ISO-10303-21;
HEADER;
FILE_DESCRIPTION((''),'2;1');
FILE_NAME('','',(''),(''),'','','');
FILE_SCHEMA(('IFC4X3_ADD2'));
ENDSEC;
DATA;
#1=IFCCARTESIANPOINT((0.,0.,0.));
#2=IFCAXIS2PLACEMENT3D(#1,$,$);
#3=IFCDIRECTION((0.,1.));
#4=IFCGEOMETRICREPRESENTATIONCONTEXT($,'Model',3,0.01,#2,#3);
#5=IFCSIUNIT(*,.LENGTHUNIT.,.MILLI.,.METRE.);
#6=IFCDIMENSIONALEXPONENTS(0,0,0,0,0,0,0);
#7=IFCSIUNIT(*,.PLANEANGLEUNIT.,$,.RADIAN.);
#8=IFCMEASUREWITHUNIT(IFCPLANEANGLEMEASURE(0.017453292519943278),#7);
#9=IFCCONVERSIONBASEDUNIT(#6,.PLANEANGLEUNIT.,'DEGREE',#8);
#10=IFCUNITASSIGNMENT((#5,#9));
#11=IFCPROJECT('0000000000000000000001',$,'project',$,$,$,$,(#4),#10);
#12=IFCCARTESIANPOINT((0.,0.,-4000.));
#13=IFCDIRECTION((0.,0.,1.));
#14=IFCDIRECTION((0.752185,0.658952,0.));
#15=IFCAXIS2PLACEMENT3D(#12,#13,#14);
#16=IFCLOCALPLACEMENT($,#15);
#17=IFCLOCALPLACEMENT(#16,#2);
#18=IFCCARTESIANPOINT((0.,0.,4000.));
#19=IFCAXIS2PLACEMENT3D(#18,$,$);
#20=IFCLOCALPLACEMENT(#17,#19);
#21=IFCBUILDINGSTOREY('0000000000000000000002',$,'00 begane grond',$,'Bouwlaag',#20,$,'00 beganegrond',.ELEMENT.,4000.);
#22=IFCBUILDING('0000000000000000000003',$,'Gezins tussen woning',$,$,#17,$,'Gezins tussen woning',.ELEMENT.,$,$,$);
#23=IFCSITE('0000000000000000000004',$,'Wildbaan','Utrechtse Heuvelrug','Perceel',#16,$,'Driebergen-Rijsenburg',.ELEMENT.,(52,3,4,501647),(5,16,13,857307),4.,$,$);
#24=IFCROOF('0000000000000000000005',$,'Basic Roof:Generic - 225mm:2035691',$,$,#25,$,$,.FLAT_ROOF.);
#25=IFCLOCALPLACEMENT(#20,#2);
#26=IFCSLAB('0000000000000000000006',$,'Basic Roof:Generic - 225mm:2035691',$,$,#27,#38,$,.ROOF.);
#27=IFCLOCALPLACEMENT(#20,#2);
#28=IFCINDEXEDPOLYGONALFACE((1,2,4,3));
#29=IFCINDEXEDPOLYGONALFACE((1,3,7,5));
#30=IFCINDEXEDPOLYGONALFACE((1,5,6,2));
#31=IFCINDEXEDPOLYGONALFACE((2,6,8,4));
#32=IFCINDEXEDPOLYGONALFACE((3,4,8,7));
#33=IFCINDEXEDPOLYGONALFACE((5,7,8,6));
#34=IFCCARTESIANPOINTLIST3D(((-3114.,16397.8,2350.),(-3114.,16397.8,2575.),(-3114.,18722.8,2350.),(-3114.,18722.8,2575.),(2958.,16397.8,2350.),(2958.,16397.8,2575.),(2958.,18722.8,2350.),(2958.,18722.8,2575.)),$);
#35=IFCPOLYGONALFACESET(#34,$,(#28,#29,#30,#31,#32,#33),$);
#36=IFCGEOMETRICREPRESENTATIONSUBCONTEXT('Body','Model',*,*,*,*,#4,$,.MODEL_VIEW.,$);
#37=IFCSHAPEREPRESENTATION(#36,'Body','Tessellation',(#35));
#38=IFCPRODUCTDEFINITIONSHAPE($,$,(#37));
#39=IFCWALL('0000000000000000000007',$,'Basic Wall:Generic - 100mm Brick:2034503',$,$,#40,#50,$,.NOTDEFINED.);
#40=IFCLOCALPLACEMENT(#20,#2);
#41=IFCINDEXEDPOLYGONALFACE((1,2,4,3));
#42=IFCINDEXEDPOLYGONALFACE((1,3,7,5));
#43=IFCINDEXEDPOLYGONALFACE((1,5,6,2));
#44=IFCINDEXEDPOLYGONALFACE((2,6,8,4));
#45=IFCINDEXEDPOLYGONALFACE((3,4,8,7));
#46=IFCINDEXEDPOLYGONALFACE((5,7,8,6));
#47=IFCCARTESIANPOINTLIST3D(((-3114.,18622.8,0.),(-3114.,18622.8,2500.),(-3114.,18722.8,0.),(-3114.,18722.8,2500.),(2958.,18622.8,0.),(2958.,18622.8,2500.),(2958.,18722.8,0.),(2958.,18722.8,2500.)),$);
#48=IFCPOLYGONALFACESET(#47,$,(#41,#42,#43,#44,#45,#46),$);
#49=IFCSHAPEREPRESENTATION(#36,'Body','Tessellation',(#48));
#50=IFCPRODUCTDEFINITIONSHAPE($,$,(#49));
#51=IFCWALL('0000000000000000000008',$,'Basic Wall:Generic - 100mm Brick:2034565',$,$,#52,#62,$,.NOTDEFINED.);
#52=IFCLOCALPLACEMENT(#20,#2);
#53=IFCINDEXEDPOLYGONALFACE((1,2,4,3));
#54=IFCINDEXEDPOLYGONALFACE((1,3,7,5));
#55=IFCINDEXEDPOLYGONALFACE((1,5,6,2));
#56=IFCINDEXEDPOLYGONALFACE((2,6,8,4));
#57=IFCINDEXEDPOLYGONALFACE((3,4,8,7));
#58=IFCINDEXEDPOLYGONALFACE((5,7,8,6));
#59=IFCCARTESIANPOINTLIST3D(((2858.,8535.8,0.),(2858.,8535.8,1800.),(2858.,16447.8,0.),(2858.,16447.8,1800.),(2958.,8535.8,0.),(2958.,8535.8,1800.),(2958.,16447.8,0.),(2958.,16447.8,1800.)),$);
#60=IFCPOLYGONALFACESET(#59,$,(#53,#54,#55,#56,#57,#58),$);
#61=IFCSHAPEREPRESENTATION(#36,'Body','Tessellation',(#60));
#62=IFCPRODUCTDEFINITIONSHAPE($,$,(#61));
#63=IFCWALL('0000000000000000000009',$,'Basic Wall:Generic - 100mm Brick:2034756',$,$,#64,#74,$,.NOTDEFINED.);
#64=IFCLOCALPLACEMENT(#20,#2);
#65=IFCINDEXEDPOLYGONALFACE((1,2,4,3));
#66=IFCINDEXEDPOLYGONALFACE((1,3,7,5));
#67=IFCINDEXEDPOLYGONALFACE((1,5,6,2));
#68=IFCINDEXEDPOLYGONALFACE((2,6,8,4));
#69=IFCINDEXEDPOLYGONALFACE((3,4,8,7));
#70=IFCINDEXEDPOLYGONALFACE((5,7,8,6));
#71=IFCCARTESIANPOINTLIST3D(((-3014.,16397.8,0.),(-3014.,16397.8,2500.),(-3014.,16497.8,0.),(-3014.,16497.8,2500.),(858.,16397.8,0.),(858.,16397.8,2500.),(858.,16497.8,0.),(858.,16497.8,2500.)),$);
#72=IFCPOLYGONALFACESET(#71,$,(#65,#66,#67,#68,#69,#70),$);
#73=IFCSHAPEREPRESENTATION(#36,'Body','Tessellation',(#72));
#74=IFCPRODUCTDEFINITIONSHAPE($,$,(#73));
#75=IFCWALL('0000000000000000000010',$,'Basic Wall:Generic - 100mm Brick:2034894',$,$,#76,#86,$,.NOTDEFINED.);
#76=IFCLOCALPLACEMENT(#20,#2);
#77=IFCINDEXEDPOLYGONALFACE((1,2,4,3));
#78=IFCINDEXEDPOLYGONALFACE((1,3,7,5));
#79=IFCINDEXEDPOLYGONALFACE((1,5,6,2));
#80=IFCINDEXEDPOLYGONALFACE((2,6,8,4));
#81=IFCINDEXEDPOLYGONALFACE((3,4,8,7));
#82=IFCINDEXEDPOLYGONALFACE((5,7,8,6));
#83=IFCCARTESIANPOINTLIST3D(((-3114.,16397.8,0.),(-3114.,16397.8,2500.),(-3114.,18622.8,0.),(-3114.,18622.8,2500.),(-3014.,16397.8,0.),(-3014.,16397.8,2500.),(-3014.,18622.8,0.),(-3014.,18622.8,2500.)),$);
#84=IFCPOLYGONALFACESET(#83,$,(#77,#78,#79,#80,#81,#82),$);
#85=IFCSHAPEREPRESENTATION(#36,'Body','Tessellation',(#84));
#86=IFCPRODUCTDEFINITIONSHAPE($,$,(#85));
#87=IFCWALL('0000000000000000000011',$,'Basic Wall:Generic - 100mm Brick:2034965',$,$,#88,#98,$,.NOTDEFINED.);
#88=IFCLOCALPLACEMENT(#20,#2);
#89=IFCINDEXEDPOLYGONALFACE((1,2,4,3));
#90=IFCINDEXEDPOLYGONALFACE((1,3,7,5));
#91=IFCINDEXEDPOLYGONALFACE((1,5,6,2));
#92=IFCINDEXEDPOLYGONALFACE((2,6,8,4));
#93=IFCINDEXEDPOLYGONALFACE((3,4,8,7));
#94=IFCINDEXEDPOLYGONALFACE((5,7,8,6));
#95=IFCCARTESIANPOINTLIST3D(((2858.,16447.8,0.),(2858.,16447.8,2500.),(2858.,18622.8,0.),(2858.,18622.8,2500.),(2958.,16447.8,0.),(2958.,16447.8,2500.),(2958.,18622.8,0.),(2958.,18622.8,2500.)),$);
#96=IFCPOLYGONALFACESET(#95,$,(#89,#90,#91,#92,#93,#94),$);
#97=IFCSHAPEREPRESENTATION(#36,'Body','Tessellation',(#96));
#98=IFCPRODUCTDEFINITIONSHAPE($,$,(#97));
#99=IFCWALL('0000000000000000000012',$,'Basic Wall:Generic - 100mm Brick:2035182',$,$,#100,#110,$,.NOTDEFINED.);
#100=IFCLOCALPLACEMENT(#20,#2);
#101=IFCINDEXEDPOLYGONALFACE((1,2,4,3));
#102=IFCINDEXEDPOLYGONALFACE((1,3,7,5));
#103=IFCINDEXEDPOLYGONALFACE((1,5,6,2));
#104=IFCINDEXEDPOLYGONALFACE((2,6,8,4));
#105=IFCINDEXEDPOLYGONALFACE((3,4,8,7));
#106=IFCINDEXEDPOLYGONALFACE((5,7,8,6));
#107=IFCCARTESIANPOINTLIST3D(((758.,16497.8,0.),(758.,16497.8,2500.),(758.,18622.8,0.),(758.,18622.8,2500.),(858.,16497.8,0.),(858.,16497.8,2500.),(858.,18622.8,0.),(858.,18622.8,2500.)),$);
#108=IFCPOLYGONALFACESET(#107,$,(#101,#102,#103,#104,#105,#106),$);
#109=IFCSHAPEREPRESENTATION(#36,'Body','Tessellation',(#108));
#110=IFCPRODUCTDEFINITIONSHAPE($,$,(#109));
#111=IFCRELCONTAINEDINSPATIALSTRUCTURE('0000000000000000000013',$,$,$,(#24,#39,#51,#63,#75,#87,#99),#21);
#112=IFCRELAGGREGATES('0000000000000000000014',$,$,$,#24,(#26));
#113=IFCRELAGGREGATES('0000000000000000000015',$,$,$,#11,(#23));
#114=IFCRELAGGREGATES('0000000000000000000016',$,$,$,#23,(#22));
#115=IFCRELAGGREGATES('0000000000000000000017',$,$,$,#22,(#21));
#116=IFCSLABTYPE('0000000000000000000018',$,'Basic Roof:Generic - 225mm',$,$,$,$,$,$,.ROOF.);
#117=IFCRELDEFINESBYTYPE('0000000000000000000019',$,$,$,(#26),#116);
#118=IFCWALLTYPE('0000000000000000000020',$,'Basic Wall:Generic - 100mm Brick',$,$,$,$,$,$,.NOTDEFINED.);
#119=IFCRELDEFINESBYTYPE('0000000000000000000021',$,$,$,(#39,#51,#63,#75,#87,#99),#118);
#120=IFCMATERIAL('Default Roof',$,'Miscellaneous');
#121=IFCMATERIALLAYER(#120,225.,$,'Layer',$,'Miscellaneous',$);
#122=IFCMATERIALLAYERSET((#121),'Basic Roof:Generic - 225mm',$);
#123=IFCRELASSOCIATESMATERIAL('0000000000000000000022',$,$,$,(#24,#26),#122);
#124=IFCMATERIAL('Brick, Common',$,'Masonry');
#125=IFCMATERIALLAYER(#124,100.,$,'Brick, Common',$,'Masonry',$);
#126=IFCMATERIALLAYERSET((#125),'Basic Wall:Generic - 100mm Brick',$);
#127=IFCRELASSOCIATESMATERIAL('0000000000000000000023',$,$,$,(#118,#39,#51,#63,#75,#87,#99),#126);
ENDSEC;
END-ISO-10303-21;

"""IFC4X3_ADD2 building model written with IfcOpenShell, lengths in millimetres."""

from ifc_helpers import new_model, entity, si_unit, converted_unit, direction, frame, frame_2d, origin, place, context, subcontext, project, spatial, rectangle, extrude, material, layer, layer_set, type_object, element, aggregate, save


model = new_model("IFC4X3_ADD2")

# Units and contexts
model_context = context("Model", 3, precision=0.01, world=origin(), true_north=direction((0.0, 1.0)))
body_context = subcontext(model_context, "Body", "Model", "MODEL_VIEW")
ifc_project = project(units=[si_unit("LENGTHUNIT", "METRE", prefix="MILLI"), converted_unit("PLANEANGLEUNIT", "DEGREE", entity("IfcPlaneAngleMeasure", 0.017453292519943278), si_unit("PLANEANGLEUNIT", "RADIAN"), dimensions=[0, 0, 0, 0, 0, 0, 0])], contexts=[model_context])

# Site, building, storey
site_placement = place(None, frame((0.0, 0.0, -4000.0), z_axis=(0.0, 0.0, 1.0), x_axis=(0.752185, 0.658952, 0.0)))
site = spatial("IfcSite", under=ifc_project, at=site_placement, Name="Wildbaan", Description="Utrechtse Heuvelrug", ObjectType="Perceel", LongName="Driebergen-Rijsenburg", CompositionType="ELEMENT", RefLatitude=(52, 3, 4, 501647), RefLongitude=(5, 16, 13, 857307), RefElevation=4.0)
building_placement = place(site_placement, origin())
building = spatial("IfcBuilding", under=site, at=building_placement, Name="Gezins tussen woning", LongName="Gezins tussen woning", CompositionType="ELEMENT")
storey_placement = place(building_placement, frame((0.0, 0.0, 4000.0)))
storey = spatial("IfcBuildingStorey", under=building, at=storey_placement, Name="00 begane grond", ObjectType="Bouwlaag", LongName="00 beganegrond", CompositionType="ELEMENT", Elevation=4000.0)

# Roof, slab
ifc_material_1 = material(Name="Default Roof", Category="Miscellaneous")
ifc_layer_1 = layer(ifc_material_1, 225.0, Name="Layer", Category="Miscellaneous")
ifc_layer_set_1 = layer_set([ifc_layer_1], Name="Basic Roof:Generic - 225mm")
roof_placement = place(storey_placement, frame((-3114.0, 16397.8, 2350.0)))
roof = element("IfcRoof", 1, at=roof_placement, inside=storey, material=ifc_layer_set_1, Name="Basic Roof:Generic - 225mm:2035691", PredefinedType="FLAT_ROOF")
slab_type = type_object("IfcSlabType", Name="Basic Roof:Generic - 225mm", PredefinedType="ROOF")
slab_placement = place(roof_placement, origin())
slab = element("IfcSlab", 2, at=slab_placement, type_object=slab_type, material=ifc_layer_set_1, Name="Basic Roof:Generic - 225mm:2035691", PredefinedType="ROOF", context=body_context, shape_type="SweptSolid", body=[
    extrude(rectangle(XDim=6072.0, YDim=2325.0, at=frame_2d((0.0, 0.0), x_axis=(1.0, 0.0))), frame((3036.0, 1162.5, 0.0)), (0.0, 0.0, 1.0), 225.0),
])
aggregate(roof, [slab])

# Walls
ifc_material_2 = material(Name="Brick, Common", Category="Masonry")
ifc_layer_2 = layer(ifc_material_2, 100.0, Name="Brick, Common", Category="Masonry")
ifc_layer_set_2 = layer_set([ifc_layer_2], Name="Basic Wall:Generic - 100mm Brick")
wall_type = type_object("IfcWallType", Name="Basic Wall:Generic - 100mm Brick", PredefinedType="NOTDEFINED", material=ifc_layer_set_2)
wall_1_placement = place(storey_placement, frame((-3114.0, 18672.8, 0.0)))
element("IfcWall", 3, at=wall_1_placement, inside=storey, type_object=wall_type, material=ifc_layer_set_2, Name="Basic Wall:Generic - 100mm Brick:2034503", PredefinedType="NOTDEFINED", context=body_context, shape_type="SweptSolid", body=[
    extrude(rectangle(XDim=6072.0, YDim=100.0, at=frame_2d((3036.0, 0.0), x_axis=(-1.0, 0.0))), origin(), (0.0, 0.0, 1.0), 2500.0),
])
wall_2_placement = place(storey_placement, frame((2908.0, 16447.8, 0.0), z_axis=(0.0, 0.0, 1.0), x_axis=(0.0, -1.0, 0.0)))
element("IfcWall", 4, at=wall_2_placement, inside=storey, type_object=wall_type, material=ifc_layer_set_2, Name="Basic Wall:Generic - 100mm Brick:2034565", PredefinedType="NOTDEFINED", context=body_context, shape_type="SweptSolid", body=[
    extrude(rectangle(XDim=7912.0, YDim=100.0, at=frame_2d((3956.0, 0.0), x_axis=(-1.0, 0.0))), origin(), (0.0, 0.0, 1.0), 1800.0),
])
wall_3_placement = place(storey_placement, frame((-3014.0, 16447.8, 0.0)))
element("IfcWall", 5, at=wall_3_placement, inside=storey, type_object=wall_type, material=ifc_layer_set_2, Name="Basic Wall:Generic - 100mm Brick:2034756", PredefinedType="NOTDEFINED", context=body_context, shape_type="SweptSolid", body=[
    extrude(rectangle(XDim=3872.0, YDim=100.0, at=frame_2d((1936.0, 0.0), x_axis=(-1.0, 0.0))), origin(), (0.0, 0.0, 1.0), 2500.0),
])
wall_4_placement = place(storey_placement, frame((-3064.0, 16397.8, 0.0), z_axis=(0.0, 0.0, 1.0), x_axis=(0.0, 1.0, 0.0)))
element("IfcWall", 6, at=wall_4_placement, inside=storey, type_object=wall_type, material=ifc_layer_set_2, Name="Basic Wall:Generic - 100mm Brick:2034894", PredefinedType="NOTDEFINED", context=body_context, shape_type="SweptSolid", body=[
    extrude(rectangle(XDim=2225.0, YDim=100.0, at=frame_2d((1112.5, 0.0), x_axis=(-1.0, 0.0))), origin(), (0.0, 0.0, 1.0), 2500.0),
])
wall_5_placement = place(storey_placement, frame((2908.0, 16447.8, 0.0), z_axis=(0.0, 0.0, 1.0), x_axis=(0.0, 1.0, 0.0)))
element("IfcWall", 7, at=wall_5_placement, inside=storey, type_object=wall_type, material=ifc_layer_set_2, Name="Basic Wall:Generic - 100mm Brick:2034965", PredefinedType="NOTDEFINED", context=body_context, shape_type="SweptSolid", body=[
    extrude(rectangle(XDim=2175.0, YDim=100.0, at=frame_2d((1087.5, 0.0), x_axis=(-1.0, 0.0))), origin(), (0.0, 0.0, 1.0), 2500.0),
])
wall_6_placement = place(storey_placement, frame((808.0, 16497.8, 0.0), z_axis=(0.0, 0.0, 1.0), x_axis=(0.0, 1.0, 0.0)))
element("IfcWall", 8, at=wall_6_placement, inside=storey, type_object=wall_type, material=ifc_layer_set_2, Name="Basic Wall:Generic - 100mm Brick:2035182", PredefinedType="NOTDEFINED", context=body_context, shape_type="SweptSolid", body=[
    extrude(rectangle(XDim=2125.0, YDim=100.0, at=frame_2d((1062.5, 0.0), x_axis=(-1.0, 0.0))), origin(), (0.0, 0.0, 1.0), 2500.0),
])

save(model, "model.ifc")
